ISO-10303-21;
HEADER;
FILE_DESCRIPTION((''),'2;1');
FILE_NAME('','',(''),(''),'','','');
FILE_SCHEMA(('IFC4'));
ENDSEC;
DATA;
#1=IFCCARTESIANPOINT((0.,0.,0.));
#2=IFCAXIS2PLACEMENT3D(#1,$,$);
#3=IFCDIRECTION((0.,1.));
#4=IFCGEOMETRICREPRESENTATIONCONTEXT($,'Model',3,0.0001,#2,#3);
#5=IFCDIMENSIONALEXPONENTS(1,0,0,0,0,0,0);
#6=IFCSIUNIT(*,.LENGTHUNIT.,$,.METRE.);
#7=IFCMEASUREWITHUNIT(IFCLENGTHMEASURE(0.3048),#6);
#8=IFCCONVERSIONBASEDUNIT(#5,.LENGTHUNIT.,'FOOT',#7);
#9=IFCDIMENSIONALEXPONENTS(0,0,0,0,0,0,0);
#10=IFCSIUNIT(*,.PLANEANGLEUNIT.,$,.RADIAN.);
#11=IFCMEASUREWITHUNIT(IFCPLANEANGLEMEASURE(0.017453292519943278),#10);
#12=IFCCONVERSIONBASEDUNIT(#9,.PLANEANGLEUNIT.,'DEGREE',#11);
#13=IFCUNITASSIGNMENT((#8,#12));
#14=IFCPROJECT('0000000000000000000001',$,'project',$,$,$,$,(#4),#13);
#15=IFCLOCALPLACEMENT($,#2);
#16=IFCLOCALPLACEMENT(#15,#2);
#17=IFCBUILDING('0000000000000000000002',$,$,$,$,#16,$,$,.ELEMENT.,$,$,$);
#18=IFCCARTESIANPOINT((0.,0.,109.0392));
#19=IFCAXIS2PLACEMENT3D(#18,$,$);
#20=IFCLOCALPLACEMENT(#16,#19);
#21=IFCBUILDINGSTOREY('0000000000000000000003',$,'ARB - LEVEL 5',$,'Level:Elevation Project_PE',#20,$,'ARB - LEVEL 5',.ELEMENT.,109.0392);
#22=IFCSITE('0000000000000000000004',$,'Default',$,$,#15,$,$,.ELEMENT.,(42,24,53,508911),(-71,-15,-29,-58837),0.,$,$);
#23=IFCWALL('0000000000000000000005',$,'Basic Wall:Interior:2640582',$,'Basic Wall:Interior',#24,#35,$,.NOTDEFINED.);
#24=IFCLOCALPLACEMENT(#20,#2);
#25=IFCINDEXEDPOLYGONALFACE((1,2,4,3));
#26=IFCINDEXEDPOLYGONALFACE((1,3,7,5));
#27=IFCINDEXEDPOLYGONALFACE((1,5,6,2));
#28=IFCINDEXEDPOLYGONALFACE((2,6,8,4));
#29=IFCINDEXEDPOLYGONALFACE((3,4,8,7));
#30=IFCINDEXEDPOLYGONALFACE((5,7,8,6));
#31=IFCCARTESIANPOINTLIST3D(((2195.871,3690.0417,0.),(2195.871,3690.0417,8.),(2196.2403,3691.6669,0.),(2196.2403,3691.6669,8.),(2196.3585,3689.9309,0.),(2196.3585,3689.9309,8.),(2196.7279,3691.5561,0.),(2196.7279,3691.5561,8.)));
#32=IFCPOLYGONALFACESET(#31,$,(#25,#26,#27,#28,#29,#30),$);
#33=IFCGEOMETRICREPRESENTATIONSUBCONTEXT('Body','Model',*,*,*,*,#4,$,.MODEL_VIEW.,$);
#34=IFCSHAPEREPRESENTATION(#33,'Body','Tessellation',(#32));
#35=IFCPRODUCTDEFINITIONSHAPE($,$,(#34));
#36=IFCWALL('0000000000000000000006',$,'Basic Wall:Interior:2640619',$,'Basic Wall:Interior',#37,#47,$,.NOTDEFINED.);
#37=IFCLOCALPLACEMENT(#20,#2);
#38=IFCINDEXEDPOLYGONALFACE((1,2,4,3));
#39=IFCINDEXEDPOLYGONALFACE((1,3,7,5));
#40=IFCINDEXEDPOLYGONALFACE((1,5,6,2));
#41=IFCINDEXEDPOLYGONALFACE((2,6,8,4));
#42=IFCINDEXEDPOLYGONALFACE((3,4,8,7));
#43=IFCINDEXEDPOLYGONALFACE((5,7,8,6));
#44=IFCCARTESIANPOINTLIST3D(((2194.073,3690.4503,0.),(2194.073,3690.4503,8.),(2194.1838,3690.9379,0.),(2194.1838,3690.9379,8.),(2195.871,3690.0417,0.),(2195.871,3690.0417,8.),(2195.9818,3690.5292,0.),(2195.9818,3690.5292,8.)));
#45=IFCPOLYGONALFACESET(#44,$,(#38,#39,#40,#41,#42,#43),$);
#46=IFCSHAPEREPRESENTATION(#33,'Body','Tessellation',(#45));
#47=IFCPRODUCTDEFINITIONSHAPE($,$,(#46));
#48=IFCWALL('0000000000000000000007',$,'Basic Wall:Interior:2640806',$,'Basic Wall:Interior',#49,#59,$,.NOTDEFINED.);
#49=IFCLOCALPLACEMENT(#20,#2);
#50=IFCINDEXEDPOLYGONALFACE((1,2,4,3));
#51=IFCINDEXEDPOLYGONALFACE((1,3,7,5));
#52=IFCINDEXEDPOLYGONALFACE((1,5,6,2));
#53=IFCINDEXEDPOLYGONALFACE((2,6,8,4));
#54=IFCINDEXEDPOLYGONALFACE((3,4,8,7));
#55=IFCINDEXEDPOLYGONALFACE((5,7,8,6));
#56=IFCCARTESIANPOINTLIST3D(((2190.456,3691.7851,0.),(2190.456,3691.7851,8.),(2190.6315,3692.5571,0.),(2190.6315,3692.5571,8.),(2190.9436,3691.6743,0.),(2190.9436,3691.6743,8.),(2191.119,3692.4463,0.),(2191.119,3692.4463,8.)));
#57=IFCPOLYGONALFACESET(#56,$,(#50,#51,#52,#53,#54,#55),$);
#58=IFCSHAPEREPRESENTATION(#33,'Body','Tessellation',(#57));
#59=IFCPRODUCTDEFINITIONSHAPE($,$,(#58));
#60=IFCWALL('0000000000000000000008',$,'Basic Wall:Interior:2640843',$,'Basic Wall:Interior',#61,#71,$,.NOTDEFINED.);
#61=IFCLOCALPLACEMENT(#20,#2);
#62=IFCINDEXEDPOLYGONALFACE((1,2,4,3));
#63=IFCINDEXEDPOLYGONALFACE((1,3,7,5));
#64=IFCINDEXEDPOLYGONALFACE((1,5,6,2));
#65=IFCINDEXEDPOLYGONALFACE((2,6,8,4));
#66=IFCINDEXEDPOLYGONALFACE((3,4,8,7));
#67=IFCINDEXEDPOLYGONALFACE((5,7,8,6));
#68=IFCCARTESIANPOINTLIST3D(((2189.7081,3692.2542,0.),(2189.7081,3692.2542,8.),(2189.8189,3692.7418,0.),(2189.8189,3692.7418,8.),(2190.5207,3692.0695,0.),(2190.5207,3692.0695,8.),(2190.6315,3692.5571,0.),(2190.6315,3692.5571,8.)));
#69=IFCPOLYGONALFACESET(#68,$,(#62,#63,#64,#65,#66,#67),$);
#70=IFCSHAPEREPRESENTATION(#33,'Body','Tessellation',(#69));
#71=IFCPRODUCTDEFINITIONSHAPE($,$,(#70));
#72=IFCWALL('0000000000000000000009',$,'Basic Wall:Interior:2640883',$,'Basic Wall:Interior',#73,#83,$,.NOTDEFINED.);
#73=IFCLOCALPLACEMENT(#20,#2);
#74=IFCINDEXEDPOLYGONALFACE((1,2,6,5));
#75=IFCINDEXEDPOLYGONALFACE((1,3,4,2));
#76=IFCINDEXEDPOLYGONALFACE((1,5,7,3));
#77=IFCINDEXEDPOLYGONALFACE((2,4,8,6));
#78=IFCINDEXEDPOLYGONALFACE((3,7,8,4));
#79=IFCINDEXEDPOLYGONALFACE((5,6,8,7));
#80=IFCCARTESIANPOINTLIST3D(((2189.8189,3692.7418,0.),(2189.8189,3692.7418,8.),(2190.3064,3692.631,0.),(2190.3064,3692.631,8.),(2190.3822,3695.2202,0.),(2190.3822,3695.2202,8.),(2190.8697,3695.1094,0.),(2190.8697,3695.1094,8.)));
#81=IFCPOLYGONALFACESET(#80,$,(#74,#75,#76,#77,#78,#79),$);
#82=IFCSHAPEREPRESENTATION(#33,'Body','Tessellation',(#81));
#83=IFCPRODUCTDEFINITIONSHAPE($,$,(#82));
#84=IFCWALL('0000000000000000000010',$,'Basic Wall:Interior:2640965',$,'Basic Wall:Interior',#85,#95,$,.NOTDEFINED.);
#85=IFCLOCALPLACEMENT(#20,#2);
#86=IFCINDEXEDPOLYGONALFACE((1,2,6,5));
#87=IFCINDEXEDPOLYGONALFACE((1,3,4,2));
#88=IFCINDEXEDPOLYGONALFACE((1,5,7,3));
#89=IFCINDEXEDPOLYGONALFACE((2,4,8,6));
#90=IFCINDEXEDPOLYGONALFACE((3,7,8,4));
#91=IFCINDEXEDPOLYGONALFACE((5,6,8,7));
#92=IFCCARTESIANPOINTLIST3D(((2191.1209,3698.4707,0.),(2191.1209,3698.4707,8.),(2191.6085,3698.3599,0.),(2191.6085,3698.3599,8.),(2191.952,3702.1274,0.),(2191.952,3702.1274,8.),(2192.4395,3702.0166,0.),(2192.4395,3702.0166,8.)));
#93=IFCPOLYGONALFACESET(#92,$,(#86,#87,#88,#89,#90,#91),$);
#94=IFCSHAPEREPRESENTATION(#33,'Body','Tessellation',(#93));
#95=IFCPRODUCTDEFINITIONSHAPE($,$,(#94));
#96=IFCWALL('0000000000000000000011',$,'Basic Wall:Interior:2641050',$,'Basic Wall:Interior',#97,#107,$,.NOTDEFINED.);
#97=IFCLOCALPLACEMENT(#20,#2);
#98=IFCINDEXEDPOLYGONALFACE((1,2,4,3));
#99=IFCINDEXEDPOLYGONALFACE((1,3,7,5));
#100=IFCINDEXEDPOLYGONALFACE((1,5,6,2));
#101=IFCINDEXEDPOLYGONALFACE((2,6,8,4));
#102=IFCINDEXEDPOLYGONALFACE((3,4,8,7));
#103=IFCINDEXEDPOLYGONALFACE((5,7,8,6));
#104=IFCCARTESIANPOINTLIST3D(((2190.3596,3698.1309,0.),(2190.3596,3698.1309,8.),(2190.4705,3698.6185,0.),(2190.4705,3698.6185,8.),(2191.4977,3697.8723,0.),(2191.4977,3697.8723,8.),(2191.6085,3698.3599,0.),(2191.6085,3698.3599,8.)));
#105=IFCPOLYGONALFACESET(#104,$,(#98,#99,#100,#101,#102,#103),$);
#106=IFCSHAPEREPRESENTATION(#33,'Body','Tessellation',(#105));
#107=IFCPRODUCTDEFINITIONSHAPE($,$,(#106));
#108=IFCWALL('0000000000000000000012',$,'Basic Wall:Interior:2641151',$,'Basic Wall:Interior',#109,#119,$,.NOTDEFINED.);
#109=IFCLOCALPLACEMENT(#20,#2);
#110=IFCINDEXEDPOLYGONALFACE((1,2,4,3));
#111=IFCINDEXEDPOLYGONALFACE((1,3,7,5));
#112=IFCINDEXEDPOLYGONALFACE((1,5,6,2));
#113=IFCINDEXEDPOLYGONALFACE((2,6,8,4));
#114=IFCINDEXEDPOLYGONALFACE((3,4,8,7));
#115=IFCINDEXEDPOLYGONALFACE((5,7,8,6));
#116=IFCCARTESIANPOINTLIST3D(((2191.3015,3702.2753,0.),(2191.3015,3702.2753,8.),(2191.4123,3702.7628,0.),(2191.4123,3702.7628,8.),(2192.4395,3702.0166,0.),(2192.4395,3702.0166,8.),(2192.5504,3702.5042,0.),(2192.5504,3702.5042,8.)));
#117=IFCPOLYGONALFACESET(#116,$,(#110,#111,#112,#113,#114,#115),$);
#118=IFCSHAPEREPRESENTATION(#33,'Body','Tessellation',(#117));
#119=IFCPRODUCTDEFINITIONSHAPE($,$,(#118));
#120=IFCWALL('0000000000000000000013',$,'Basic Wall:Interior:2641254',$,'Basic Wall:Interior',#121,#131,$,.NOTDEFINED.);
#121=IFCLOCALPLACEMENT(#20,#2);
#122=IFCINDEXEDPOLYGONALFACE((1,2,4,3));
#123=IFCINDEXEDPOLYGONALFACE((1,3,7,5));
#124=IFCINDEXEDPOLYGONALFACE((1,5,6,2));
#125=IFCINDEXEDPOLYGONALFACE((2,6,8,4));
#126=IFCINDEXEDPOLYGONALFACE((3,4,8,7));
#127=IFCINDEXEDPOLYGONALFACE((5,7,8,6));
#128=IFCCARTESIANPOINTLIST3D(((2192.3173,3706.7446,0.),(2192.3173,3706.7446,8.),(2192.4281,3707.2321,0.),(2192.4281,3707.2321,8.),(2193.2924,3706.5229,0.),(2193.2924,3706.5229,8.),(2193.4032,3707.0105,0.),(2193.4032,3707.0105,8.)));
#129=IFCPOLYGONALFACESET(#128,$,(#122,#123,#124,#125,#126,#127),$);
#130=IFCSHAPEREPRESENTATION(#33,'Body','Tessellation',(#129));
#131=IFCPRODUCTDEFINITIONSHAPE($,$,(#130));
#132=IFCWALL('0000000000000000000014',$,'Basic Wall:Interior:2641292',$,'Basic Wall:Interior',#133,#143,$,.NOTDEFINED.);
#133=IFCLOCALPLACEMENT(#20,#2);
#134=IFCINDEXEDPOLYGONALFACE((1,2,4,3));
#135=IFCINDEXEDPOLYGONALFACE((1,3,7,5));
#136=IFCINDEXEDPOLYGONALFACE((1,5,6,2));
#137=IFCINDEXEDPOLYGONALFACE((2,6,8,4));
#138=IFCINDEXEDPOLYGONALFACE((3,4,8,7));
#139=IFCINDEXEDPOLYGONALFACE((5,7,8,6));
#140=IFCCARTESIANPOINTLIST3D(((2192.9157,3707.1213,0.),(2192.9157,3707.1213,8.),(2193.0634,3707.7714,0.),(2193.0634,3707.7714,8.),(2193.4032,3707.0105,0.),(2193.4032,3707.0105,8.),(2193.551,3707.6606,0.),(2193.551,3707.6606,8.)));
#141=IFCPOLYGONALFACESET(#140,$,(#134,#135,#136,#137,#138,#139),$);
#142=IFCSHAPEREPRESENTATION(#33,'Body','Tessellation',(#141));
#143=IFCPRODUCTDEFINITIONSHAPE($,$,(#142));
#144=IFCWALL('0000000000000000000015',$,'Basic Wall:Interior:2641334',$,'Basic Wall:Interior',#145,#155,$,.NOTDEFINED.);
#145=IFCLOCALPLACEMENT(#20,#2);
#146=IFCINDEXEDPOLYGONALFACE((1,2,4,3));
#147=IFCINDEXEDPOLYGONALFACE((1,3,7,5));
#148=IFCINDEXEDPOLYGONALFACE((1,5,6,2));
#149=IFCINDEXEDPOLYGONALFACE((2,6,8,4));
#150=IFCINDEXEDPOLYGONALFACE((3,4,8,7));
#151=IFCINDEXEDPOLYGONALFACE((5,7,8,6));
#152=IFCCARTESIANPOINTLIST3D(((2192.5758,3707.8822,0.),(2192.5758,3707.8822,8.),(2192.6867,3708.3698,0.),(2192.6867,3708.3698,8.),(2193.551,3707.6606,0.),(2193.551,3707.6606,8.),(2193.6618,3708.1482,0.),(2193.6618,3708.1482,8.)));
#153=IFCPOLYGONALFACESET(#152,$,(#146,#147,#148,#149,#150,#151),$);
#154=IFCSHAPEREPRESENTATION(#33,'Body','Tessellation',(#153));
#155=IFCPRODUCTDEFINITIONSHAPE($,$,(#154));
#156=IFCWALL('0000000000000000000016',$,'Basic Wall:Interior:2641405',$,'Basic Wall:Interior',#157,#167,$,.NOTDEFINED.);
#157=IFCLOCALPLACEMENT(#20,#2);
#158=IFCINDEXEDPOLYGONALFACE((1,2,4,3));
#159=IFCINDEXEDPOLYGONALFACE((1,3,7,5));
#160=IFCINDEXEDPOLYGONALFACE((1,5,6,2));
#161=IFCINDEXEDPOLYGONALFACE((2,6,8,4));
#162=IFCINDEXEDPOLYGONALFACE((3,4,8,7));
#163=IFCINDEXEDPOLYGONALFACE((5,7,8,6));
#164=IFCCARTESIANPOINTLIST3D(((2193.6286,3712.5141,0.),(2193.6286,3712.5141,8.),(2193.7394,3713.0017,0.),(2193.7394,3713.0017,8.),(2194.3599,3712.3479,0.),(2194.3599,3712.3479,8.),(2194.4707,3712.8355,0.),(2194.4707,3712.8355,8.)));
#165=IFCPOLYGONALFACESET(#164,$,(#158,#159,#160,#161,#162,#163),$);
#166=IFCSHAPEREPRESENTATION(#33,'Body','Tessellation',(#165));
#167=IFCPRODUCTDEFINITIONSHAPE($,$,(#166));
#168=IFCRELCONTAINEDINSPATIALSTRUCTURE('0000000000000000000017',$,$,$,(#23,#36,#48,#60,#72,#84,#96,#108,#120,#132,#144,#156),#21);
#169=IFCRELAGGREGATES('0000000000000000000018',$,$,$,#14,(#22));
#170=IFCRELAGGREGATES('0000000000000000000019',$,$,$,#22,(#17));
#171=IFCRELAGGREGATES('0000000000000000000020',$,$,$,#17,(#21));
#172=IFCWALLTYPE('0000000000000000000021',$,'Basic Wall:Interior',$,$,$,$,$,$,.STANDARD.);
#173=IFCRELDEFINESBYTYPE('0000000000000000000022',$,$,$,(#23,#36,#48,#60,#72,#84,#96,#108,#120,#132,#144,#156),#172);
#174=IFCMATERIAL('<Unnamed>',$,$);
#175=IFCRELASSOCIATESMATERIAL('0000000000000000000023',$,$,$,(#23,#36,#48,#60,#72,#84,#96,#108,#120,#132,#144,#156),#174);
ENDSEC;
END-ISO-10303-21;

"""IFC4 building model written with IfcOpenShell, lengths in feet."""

from ifc_helpers import new_model, entity, si_unit, converted_unit, direction, frame, origin, place, context, subcontext, project, spatial, indexed_curve, outline, extrude, material, type_object, element, save


model = new_model("IFC4")

# Units and contexts
model_context = context("Model", 3, precision=0.0001, world=origin(), true_north=direction((0.0, 1.0)))
body_context = subcontext(model_context, "Body", "Model", "MODEL_VIEW")
ifc_project = project(units=[converted_unit("LENGTHUNIT", "FOOT", entity("IfcLengthMeasure", 0.3048), si_unit("LENGTHUNIT", "METRE"), dimensions=[1, 0, 0, 0, 0, 0, 0]), converted_unit("PLANEANGLEUNIT", "DEGREE", entity("IfcPlaneAngleMeasure", 0.017453292519943278), si_unit("PLANEANGLEUNIT", "RADIAN"), dimensions=[0, 0, 0, 0, 0, 0, 0])], contexts=[model_context])

# Site, building, storey
site_placement = place(None, origin())
site = spatial("IfcSite", under=ifc_project, at=site_placement, Name="Default", CompositionType="ELEMENT", RefLatitude=(42, 24, 53, 508911), RefLongitude=(-71, -15, -29, -58837), RefElevation=0.0)
building_placement = place(site_placement, origin())
building = spatial("IfcBuilding", under=site, at=building_placement, CompositionType="ELEMENT")
storey_placement = place(building_placement, frame((0.0, 0.0, 109.0392)))
storey = spatial("IfcBuildingStorey", under=building, at=storey_placement, Name="ARB - LEVEL 5", ObjectType="Level:Elevation Project_PE", LongName="ARB - LEVEL 5", CompositionType="ELEMENT", Elevation=109.0392)

# Walls
ifc_material_1 = material(Name="<Unnamed>")
wall_type = type_object("IfcWallType", Name="Basic Wall:Interior", PredefinedType="STANDARD")
wall_1_placement = place(storey_placement, frame((2196.4841, 3691.6115, 0.0), z_axis=(0.0, 0.0, 1.0), x_axis=(-0.221622, -0.975133, 0.0)))
element("IfcWall", 1, at=wall_1_placement, inside=storey, type_object=wall_type, material=ifc_material_1, Name="Basic Wall:Interior:2640582", ObjectType="Basic Wall:Interior", PredefinedType="NOTDEFINED", context=body_context, shape_type="SweptSolid", body=[
    extrude(outline(indexed_curve([(1.6667, 0.25), (0.0, 0.25), (0.0, -0.25), (1.6667, -0.25), (1.6667, 0.25)], self_intersect=False)), origin(), (0.0, 0.0, 1.0), 8.0),
])
wall_2_placement = place(storey_placement, frame((2195.9264, 3690.2855, 0.0), z_axis=(0.0, 0.0, 1.0), x_axis=(-0.975133, 0.221622, 0.0)))
element("IfcWall", 2, at=wall_2_placement, inside=storey, type_object=wall_type, material=ifc_material_1, Name="Basic Wall:Interior:2640619", ObjectType="Basic Wall:Interior", PredefinedType="NOTDEFINED", context=body_context, shape_type="SweptSolid", body=[
    extrude(outline(indexed_curve([(1.8439, 0.25), (0.0, 0.25), (0.0, -0.25), (1.8439, -0.25), (1.8439, 0.25)], self_intersect=False)), origin(), (0.0, 0.0, 1.0), 8.0),
])
wall_3_placement = place(storey_placement, frame((2190.6998, 3691.7297, 0.0), z_axis=(0.0, 0.0, 1.0), x_axis=(0.221622, 0.975133, 0.0)))
element("IfcWall", 3, at=wall_3_placement, inside=storey, type_object=wall_type, material=ifc_material_1, Name="Basic Wall:Interior:2640806", ObjectType="Basic Wall:Interior", PredefinedType="NOTDEFINED", context=body_context, shape_type="SweptSolid", body=[
    extrude(outline(indexed_curve([(0.7917, 0.25), (0.0, 0.25), (0.0, -0.25), (0.7917, -0.25), (0.7917, 0.25)], self_intersect=False)), origin(), (0.0, 0.0, 1.0), 8.0),
])
wall_4_placement = place(storey_placement, frame((2190.5761, 3692.3133, 0.0), z_axis=(0.0, 0.0, 1.0), x_axis=(-0.975133, 0.221622, 0.0)))
element("IfcWall", 4, at=wall_4_placement, inside=storey, type_object=wall_type, material=ifc_material_1, Name="Basic Wall:Interior:2640843", ObjectType="Basic Wall:Interior", PredefinedType="NOTDEFINED", context=body_context, shape_type="SweptSolid", body=[
    extrude(outline(indexed_curve([(0.8333, 0.25), (0.0, 0.25), (0.0, -0.25), (0.8333, -0.25), (0.8333, 0.25)], self_intersect=False)), origin(), (0.0, 0.0, 1.0), 8.0),
])
wall_5_placement = place(storey_placement, frame((2190.0627, 3692.6864, 0.0), z_axis=(0.0, 0.0, 1.0), x_axis=(0.221622, 0.975133, 0.0)))
element("IfcWall", 5, at=wall_5_placement, inside=storey, type_object=wall_type, material=ifc_material_1, Name="Basic Wall:Interior:2640883", ObjectType="Basic Wall:Interior", PredefinedType="NOTDEFINED", context=body_context, shape_type="SweptSolid", body=[
    extrude(outline(indexed_curve([(2.5417, 0.25), (0.0, 0.25), (0.0, -0.25), (2.5417, -0.25), (2.5417, 0.25)], self_intersect=False)), origin(), (0.0, 0.0, 1.0), 8.0),
])
wall_6_placement = place(storey_placement, frame((2191.3647, 3698.4153, 0.0), z_axis=(0.0, 0.0, 1.0), x_axis=(0.221622, 0.975133, 0.0)))
element("IfcWall", 6, at=wall_6_placement, inside=storey, type_object=wall_type, material=ifc_material_1, Name="Basic Wall:Interior:2640965", ObjectType="Basic Wall:Interior", PredefinedType="NOTDEFINED", context=body_context, shape_type="SweptSolid", body=[
    extrude(outline(indexed_curve([(3.75, 0.25), (0.0, 0.25), (0.0, -0.25), (3.75, -0.25), (3.75, 0.25)], self_intersect=False)), origin(), (0.0, 0.0, 1.0), 8.0),
])
wall_7_placement = place(storey_placement, frame((2190.4151, 3698.3747, 0.0), z_axis=(0.0, 0.0, 1.0), x_axis=(0.975133, -0.221622, 0.0)))
element("IfcWall", 7, at=wall_7_placement, inside=storey, type_object=wall_type, material=ifc_material_1, Name="Basic Wall:Interior:2641050", ObjectType="Basic Wall:Interior", PredefinedType="NOTDEFINED", context=body_context, shape_type="SweptSolid", body=[
    extrude(outline(indexed_curve([(1.167, 0.25), (0.0, 0.25), (0.0, -0.25), (1.167, -0.25), (1.167, 0.25)], self_intersect=False)), origin(), (0.0, 0.0, 1.0), 8.0),
])
wall_8_placement = place(storey_placement, frame((2192.495, 3702.2604, 0.0), z_axis=(0.0, 0.0, 1.0), x_axis=(-0.975133, 0.221622, 0.0)))
element("IfcWall", 8, at=wall_8_placement, inside=storey, type_object=wall_type, material=ifc_material_1, Name="Basic Wall:Interior:2641151", ObjectType="Basic Wall:Interior", PredefinedType="NOTDEFINED", context=body_context, shape_type="SweptSolid", body=[
    extrude(outline(indexed_curve([(1.167, 0.25), (0.0, 0.25), (0.0, -0.25), (1.167, -0.25), (1.167, 0.25)], self_intersect=False)), origin(), (0.0, 0.0, 1.0), 8.0),
])
wall_9_placement = place(storey_placement, frame((2192.3727, 3706.9883, 0.0), z_axis=(0.0, 0.0, 1.0), x_axis=(0.975133, -0.221622, 0.0)))
element("IfcWall", 9, at=wall_9_placement, inside=storey, type_object=wall_type, material=ifc_material_1, Name="Basic Wall:Interior:2641254", ObjectType="Basic Wall:Interior", PredefinedType="NOTDEFINED", context=body_context, shape_type="SweptSolid", body=[
    extrude(outline(indexed_curve([(1.0, 0.25), (0.0, 0.25), (0.0, -0.25), (1.0, -0.25), (1.0, 0.25)], self_intersect=False)), origin(), (0.0, 0.0, 1.0), 8.0),
])
wall_10_placement = place(storey_placement, frame((2193.1595, 3707.0659, 0.0), z_axis=(0.0, 0.0, 1.0), x_axis=(0.221622, 0.975133, 0.0)))
element("IfcWall", 10, at=wall_10_placement, inside=storey, type_object=wall_type, material=ifc_material_1, Name="Basic Wall:Interior:2641292", ObjectType="Basic Wall:Interior", PredefinedType="NOTDEFINED", context=body_context, shape_type="SweptSolid", body=[
    extrude(outline(indexed_curve([(0.6667, 0.25), (0.0, 0.25), (0.0, -0.25), (0.6667, -0.25), (0.6667, 0.25)], self_intersect=False)), origin(), (0.0, 0.0, 1.0), 8.0),
])
wall_11_placement = place(storey_placement, frame((2193.6064, 3707.9044, 0.0), z_axis=(0.0, 0.0, 1.0), x_axis=(-0.975133, 0.221622, 0.0)))
element("IfcWall", 11, at=wall_11_placement, inside=storey, type_object=wall_type, material=ifc_material_1, Name="Basic Wall:Interior:2641334", ObjectType="Basic Wall:Interior", PredefinedType="NOTDEFINED", context=body_context, shape_type="SweptSolid", body=[
    extrude(outline(indexed_curve([(1.0, 0.25), (0.0, 0.25), (0.0, -0.25), (1.0, -0.25), (1.0, 0.25)], self_intersect=False)), origin(), (0.0, 0.0, 1.0), 8.0),
])
wall_12_placement = place(storey_placement, frame((2193.684, 3712.7579, 0.0), z_axis=(0.0, 0.0, 1.0), x_axis=(0.975133, -0.221622, 0.0)))
element("IfcWall", 12, at=wall_12_placement, inside=storey, type_object=wall_type, material=ifc_material_1, Name="Basic Wall:Interior:2641405", ObjectType="Basic Wall:Interior", PredefinedType="NOTDEFINED", context=body_context, shape_type="SweptSolid", body=[
    extrude(outline(indexed_curve([(0.75, 0.25), (0.0, 0.25), (0.0, -0.25), (0.75, -0.25), (0.75, 0.25)], self_intersect=False)), origin(), (0.0, 0.0, 1.0), 8.0),
])

save(model, "model.ifc")
